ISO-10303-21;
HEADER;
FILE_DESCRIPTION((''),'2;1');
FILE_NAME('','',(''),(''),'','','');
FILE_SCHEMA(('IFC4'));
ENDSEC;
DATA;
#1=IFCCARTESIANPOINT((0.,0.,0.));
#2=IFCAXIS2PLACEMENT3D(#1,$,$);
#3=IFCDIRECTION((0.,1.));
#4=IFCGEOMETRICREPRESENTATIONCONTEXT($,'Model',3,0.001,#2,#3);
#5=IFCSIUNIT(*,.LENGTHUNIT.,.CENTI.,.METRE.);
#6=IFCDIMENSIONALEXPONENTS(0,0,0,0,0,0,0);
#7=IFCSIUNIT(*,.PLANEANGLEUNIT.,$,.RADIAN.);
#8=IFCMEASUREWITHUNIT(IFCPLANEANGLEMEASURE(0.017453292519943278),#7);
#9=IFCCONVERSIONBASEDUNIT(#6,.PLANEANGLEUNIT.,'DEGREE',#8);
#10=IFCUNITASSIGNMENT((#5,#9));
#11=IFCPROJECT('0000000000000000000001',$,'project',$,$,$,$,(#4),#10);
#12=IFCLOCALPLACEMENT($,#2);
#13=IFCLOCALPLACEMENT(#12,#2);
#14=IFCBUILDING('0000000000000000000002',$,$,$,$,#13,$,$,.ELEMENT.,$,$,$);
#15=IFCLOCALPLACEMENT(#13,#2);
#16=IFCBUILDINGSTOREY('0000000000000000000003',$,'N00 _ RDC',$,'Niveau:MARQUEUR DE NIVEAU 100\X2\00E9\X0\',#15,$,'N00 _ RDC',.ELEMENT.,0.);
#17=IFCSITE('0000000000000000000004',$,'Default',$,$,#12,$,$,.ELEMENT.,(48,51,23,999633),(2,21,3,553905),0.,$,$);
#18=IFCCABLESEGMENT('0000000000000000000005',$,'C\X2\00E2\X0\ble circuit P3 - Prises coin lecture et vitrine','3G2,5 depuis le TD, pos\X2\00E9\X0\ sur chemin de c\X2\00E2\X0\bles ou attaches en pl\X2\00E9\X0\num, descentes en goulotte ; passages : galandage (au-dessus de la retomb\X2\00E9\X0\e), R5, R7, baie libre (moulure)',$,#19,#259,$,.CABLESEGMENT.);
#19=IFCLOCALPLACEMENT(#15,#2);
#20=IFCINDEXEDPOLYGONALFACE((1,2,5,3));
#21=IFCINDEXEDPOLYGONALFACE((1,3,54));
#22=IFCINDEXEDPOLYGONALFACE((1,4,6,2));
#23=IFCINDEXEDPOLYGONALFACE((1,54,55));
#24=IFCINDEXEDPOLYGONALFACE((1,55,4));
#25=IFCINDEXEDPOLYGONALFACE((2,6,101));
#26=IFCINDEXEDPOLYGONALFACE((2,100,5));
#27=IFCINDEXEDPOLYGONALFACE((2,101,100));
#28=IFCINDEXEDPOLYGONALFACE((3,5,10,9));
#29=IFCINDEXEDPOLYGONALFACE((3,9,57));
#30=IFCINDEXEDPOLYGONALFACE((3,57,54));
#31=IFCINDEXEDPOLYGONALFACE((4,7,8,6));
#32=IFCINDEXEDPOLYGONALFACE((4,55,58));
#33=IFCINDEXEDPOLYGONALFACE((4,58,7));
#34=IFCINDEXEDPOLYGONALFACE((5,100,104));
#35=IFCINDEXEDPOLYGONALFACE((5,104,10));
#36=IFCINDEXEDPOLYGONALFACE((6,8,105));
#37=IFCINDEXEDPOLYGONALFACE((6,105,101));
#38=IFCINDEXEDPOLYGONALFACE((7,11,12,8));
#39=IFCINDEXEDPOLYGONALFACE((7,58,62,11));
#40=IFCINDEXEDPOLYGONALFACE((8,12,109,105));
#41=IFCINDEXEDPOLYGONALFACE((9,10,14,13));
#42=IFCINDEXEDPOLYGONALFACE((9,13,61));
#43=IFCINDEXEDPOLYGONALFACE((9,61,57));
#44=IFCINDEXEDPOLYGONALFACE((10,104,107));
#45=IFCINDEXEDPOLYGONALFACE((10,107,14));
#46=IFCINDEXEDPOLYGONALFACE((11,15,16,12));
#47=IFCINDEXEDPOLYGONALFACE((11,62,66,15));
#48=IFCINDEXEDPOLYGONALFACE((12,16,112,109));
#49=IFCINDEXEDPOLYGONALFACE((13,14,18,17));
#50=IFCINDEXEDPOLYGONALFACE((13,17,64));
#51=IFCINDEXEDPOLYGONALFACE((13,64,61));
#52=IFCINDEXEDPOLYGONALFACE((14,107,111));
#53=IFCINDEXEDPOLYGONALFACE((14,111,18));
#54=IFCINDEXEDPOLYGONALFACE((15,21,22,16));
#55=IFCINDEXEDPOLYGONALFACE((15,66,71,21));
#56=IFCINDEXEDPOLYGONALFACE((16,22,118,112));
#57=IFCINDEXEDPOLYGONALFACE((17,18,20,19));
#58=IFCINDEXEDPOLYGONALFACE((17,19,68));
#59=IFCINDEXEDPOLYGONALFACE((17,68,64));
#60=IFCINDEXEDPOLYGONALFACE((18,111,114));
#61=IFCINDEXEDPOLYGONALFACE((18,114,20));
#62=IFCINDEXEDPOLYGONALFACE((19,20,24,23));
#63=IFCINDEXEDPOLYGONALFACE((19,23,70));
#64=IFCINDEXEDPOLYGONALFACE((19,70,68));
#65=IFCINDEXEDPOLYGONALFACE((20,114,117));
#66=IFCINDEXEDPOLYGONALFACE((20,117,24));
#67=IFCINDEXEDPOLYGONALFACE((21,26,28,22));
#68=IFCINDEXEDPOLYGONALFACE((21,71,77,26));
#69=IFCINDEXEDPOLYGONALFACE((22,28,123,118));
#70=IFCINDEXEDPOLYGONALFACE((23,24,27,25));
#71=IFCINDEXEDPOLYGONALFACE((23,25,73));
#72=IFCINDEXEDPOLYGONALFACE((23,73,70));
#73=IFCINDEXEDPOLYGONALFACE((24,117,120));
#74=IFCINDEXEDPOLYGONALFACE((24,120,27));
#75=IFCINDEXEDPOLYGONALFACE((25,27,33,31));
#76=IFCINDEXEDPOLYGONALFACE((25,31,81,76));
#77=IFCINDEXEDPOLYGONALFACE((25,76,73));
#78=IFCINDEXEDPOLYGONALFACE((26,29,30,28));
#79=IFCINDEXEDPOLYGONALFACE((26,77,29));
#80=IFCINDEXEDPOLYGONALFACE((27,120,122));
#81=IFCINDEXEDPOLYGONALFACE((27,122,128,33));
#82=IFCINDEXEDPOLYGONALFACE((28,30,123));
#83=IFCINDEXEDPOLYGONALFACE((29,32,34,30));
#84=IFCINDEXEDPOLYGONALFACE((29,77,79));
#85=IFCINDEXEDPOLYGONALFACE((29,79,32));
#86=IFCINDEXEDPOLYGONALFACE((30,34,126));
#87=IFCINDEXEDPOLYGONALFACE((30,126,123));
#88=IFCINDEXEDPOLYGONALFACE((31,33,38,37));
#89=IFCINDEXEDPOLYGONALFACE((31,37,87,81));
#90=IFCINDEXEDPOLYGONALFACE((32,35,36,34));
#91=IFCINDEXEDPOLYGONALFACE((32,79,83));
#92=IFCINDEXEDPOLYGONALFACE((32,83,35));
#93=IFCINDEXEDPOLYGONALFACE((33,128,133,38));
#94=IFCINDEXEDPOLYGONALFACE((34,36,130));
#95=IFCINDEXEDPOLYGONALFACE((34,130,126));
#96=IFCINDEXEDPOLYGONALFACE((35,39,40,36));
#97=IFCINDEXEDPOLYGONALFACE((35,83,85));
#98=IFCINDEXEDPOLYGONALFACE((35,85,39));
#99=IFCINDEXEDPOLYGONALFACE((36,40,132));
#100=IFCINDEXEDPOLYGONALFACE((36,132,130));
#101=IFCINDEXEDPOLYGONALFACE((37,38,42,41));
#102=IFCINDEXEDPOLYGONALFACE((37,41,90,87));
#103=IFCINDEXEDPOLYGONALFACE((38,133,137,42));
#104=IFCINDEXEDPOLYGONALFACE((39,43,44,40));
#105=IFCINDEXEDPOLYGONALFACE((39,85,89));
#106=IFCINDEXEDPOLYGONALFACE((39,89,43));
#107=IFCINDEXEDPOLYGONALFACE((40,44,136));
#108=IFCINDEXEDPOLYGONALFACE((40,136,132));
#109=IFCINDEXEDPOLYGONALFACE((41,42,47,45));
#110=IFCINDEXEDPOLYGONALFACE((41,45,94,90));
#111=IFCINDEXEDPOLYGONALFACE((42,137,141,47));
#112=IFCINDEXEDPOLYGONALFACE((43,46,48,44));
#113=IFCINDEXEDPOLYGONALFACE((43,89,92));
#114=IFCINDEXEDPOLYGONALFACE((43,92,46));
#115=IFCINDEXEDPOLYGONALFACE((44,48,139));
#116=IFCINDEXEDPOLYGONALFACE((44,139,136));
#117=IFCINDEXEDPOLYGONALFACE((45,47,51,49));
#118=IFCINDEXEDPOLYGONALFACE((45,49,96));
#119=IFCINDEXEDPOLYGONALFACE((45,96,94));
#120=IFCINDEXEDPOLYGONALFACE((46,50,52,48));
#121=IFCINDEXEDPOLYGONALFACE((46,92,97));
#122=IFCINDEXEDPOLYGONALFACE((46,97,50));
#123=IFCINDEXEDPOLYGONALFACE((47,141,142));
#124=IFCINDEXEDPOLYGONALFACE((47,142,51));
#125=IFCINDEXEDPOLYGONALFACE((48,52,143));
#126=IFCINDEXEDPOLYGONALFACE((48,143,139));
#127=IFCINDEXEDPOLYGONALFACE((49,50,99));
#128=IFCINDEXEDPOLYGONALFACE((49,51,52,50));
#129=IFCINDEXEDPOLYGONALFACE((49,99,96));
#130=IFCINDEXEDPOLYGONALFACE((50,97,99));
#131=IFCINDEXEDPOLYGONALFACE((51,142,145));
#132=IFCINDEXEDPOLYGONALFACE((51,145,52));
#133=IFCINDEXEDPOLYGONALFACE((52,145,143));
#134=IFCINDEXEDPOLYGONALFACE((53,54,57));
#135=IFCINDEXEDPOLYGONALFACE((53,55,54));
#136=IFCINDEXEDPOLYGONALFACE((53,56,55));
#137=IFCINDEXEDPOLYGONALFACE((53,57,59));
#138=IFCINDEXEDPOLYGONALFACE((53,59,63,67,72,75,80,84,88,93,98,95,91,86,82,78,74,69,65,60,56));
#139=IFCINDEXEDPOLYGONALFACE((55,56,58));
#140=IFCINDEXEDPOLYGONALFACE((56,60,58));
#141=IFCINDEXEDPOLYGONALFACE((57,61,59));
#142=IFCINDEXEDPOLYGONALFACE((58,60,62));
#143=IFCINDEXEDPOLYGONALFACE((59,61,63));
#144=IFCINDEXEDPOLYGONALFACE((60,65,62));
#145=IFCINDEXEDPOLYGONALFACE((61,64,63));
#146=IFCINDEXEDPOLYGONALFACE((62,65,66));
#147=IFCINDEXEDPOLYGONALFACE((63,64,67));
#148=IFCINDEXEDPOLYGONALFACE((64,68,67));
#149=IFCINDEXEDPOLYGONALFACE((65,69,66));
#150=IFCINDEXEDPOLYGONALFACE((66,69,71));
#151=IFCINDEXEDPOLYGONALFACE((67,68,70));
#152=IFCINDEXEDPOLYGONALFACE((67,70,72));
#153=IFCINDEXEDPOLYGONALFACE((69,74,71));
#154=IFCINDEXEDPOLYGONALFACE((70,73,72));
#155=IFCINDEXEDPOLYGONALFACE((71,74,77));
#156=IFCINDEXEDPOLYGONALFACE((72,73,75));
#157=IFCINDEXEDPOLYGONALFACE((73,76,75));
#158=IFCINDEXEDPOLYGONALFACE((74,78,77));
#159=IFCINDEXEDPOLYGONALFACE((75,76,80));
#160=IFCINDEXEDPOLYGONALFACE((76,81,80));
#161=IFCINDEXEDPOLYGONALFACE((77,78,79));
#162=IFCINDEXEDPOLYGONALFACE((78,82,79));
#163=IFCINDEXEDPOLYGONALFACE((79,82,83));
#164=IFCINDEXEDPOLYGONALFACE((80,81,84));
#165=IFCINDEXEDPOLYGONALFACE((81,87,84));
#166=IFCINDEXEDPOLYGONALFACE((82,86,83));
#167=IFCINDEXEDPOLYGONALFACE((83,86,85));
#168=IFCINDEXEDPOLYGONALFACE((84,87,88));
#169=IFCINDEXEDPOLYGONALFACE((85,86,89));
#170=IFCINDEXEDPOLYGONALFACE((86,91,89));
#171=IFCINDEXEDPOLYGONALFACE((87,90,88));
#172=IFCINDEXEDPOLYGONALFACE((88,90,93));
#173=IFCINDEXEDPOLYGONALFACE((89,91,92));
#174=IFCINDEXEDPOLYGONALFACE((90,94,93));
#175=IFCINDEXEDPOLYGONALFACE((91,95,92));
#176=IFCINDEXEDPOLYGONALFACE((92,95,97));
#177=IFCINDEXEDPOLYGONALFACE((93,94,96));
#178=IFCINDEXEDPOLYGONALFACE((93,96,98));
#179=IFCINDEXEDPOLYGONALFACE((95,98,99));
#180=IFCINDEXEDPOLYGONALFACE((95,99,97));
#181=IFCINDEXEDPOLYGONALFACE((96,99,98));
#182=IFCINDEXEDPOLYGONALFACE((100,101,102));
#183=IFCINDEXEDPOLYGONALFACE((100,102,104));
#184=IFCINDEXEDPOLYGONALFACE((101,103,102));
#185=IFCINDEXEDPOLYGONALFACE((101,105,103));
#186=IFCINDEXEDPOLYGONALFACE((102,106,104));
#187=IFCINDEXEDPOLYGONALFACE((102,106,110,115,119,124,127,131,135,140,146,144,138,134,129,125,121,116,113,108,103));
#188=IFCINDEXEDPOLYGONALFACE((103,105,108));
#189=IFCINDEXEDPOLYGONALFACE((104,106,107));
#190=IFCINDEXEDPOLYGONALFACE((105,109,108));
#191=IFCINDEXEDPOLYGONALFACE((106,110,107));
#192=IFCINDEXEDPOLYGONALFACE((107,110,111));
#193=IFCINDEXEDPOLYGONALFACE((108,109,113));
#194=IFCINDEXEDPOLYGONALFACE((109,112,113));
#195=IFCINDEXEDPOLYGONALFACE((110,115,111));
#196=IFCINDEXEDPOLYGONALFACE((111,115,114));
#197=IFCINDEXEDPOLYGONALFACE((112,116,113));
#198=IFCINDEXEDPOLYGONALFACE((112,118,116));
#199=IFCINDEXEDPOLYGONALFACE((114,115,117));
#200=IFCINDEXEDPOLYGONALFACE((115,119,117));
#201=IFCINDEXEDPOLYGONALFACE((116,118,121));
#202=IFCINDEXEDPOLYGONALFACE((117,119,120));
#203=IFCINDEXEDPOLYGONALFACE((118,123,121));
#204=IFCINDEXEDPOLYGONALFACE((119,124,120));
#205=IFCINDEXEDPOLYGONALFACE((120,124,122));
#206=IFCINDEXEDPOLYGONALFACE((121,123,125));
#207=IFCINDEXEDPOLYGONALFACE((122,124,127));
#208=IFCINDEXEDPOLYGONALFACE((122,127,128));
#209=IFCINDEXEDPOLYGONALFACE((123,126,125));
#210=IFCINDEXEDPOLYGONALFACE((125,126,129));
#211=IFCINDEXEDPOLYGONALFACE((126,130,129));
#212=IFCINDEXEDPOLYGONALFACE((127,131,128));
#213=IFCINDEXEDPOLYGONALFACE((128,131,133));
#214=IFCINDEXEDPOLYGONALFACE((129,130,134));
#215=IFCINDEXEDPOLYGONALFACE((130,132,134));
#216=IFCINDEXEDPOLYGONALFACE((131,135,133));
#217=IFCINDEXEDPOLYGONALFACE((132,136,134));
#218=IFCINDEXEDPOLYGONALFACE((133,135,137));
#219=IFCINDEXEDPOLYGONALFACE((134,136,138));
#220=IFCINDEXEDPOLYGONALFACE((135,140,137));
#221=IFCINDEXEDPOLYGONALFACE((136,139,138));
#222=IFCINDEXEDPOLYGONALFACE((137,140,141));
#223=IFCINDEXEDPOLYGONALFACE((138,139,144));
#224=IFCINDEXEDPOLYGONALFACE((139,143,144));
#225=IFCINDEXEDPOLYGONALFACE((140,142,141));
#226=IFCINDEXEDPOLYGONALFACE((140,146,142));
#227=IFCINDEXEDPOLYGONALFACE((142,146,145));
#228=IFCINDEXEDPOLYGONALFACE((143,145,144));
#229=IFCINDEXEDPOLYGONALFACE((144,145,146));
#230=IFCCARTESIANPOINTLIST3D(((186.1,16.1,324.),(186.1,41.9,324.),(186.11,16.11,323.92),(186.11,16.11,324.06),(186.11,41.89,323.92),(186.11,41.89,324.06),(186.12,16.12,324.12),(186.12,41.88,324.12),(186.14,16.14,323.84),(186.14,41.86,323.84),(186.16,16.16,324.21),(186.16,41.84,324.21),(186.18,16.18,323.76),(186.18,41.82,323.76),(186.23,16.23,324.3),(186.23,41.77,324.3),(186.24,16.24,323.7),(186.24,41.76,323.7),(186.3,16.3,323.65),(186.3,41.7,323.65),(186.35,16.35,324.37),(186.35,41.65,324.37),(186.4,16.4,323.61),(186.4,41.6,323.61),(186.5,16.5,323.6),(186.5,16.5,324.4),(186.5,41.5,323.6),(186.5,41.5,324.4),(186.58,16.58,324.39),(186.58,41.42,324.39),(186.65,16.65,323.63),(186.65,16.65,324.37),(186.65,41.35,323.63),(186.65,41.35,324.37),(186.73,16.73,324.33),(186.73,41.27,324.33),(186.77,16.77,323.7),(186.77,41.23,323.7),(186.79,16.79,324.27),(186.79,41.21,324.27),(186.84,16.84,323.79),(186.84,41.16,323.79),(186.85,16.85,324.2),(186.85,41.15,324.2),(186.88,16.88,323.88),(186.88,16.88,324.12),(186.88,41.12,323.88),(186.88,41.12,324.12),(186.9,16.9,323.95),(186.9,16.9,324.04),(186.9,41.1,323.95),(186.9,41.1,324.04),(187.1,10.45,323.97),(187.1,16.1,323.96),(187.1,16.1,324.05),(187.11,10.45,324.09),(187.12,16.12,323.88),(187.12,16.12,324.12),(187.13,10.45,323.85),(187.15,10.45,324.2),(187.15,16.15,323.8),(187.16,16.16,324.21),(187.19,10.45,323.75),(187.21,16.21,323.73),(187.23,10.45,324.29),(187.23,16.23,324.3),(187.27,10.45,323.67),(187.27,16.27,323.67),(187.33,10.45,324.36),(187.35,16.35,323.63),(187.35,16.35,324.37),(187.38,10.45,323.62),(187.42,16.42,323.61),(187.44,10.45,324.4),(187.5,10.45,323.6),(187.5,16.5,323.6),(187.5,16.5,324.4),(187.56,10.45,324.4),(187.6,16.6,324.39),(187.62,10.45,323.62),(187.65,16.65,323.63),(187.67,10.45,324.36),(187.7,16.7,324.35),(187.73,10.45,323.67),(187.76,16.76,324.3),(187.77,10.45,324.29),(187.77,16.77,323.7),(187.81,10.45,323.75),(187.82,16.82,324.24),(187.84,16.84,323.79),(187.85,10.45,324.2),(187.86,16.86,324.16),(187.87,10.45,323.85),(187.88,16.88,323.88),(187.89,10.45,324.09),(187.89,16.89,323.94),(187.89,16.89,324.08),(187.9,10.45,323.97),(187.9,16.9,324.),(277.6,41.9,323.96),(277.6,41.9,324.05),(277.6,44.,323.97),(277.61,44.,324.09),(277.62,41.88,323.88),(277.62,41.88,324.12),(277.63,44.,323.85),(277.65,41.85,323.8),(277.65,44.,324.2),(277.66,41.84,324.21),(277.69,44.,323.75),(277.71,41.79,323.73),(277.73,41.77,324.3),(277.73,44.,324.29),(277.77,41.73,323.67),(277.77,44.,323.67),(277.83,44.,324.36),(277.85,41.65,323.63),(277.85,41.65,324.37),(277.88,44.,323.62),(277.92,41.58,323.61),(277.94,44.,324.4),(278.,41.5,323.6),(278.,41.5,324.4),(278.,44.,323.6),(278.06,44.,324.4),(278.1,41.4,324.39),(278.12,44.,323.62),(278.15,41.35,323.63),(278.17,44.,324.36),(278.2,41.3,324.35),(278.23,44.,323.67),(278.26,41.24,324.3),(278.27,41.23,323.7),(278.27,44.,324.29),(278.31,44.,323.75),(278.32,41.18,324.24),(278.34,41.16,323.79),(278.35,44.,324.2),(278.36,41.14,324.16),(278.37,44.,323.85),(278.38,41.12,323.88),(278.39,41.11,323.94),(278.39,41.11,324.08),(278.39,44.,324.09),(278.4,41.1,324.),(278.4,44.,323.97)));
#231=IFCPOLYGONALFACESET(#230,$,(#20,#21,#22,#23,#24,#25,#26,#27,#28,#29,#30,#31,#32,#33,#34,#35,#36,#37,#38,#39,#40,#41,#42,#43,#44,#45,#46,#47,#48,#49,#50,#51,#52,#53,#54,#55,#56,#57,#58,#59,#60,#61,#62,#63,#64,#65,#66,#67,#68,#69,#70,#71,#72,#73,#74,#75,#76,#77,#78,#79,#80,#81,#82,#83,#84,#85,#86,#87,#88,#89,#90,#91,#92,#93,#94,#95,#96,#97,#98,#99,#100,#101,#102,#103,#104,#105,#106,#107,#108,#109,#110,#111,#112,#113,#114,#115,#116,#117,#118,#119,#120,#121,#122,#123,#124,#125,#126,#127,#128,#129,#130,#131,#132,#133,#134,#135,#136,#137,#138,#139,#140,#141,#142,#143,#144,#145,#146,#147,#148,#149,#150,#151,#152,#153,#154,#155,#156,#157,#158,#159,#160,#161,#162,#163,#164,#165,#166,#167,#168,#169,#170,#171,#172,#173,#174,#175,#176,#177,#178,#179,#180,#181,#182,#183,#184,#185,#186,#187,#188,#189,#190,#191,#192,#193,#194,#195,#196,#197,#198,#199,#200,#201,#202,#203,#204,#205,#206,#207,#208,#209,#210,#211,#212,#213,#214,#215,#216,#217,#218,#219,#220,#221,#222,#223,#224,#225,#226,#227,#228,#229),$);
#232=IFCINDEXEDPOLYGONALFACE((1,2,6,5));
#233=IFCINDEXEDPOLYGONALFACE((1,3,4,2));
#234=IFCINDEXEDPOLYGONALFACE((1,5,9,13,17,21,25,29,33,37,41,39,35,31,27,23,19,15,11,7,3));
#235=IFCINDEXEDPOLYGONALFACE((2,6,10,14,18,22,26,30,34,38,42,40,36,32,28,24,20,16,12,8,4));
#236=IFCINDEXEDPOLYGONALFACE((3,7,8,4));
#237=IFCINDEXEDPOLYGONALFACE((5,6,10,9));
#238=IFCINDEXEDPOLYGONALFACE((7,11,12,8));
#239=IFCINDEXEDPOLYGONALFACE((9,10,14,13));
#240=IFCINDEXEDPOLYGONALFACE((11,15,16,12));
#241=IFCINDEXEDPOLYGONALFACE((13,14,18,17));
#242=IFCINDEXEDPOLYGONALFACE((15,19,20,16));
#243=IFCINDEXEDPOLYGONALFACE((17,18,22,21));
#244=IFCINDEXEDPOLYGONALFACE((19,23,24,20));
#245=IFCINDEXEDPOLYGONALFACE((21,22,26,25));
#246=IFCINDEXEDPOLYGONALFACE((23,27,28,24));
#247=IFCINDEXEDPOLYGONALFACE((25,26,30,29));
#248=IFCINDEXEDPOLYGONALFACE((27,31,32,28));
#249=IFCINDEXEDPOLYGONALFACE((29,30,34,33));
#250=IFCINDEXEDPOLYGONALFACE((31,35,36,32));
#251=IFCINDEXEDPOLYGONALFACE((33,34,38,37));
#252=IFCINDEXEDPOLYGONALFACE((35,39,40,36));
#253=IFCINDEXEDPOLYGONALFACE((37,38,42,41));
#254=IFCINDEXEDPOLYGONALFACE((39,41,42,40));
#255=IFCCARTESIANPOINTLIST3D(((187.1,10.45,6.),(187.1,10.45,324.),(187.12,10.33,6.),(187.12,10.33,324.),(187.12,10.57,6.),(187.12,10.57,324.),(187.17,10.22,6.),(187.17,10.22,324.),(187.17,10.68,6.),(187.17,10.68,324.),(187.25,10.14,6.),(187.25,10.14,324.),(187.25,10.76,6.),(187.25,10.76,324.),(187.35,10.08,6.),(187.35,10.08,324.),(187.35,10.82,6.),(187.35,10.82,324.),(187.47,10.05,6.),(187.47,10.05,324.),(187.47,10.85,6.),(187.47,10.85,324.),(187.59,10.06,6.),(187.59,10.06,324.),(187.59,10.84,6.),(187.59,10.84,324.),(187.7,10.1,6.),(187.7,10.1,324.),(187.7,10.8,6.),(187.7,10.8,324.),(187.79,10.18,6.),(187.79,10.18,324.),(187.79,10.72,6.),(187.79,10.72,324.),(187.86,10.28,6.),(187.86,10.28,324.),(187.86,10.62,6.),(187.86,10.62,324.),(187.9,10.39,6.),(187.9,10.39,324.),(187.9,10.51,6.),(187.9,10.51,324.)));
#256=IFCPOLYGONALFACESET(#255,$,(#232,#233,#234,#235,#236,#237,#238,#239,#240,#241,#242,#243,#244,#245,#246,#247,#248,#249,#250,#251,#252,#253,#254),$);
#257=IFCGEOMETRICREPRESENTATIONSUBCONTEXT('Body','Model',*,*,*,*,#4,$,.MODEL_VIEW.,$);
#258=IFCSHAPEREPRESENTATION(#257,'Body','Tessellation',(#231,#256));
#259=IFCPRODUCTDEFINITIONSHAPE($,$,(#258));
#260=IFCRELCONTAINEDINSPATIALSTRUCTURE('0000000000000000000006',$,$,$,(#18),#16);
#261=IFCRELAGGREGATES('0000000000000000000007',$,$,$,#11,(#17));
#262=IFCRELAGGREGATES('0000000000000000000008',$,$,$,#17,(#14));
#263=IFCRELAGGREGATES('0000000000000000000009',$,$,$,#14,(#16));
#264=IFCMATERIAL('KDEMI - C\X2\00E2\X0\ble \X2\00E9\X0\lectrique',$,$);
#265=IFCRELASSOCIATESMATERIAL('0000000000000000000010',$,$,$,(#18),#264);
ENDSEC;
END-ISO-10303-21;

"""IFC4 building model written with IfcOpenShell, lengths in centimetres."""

from ifc_helpers import new_model, entity, si_unit, converted_unit, direction, origin, origin_with_axes, place, context, subcontext, project, spatial, material, element, save


model = new_model("IFC4")

# Units and contexts
model_context = context("Model", 3, precision=0.001, world=origin(), true_north=direction((0.0, 1.0)))
body_context = subcontext(model_context, "Body", "Model", "MODEL_VIEW")
ifc_project = project(units=[si_unit("LENGTHUNIT", "METRE", prefix="CENTI"), converted_unit("PLANEANGLEUNIT", "DEGREE", entity("IfcPlaneAngleMeasure", 0.017453292519943278), si_unit("PLANEANGLEUNIT", "RADIAN"), dimensions=[0, 0, 0, 0, 0, 0, 0])], contexts=[model_context])

# Site, building, storey
site_placement = place(None, origin())
site = spatial("IfcSite", under=ifc_project, at=site_placement, Name="Default", CompositionType="ELEMENT", RefLatitude=(48, 51, 23, 999633), RefLongitude=(2, 21, 3, 553905), RefElevation=0.0)
building_placement = place(site_placement, origin())
building = spatial("IfcBuilding", under=site, at=building_placement, CompositionType="ELEMENT")
storey_placement = place(building_placement, origin())
storey = spatial("IfcBuildingStorey", under=building, at=storey_placement, Name="N00 _ RDC", ObjectType="Niveau:MARQUEUR DE NIVEAU 100é", LongName="N00 _ RDC", CompositionType="ELEMENT", Elevation=0.0)

# Cable segment
ifc_material_1 = material(Name="KDEMI - Câble électrique")
cable_segment_1_placement = place(storey_placement, origin_with_axes())
element("IfcCableSegment", 1, at=cable_segment_1_placement, inside=storey, material=ifc_material_1, Name="Câble circuit P3 - Prises coin lecture et vitrine", Description="3G2,5 depuis le TD, posé sur chemin de câbles ou attaches en plénum, descentes en goulotte ; passages : galandage (au-dessus de la retombée), R5, R7, baie libre (moulure)", PredefinedType="CABLESEGMENT", context=body_context, shape_type="AdvancedSweptSolid", body=[
    entity("IfcSweptDiskSolid", entity("IfcPolyline", [entity("IfcCartesianPoint", [278.0, 44.0, 324.0]), entity("IfcCartesianPoint", [278.0, 41.5, 324.0]), entity("IfcCartesianPoint", [186.5, 41.5, 324.0]), entity("IfcCartesianPoint", [186.5, 16.5, 324.0]), entity("IfcCartesianPoint", [187.5, 16.5, 324.0]), entity("IfcCartesianPoint", [187.5, 10.45, 324.0])]), 0.4),
    entity("IfcSweptDiskSolid", entity("IfcPolyline", [entity("IfcCartesianPoint", [187.5, 10.45, 324.0]), entity("IfcCartesianPoint", [187.5, 10.45, 6.0])]), 0.4),
])

save(model, "model.ifc")
